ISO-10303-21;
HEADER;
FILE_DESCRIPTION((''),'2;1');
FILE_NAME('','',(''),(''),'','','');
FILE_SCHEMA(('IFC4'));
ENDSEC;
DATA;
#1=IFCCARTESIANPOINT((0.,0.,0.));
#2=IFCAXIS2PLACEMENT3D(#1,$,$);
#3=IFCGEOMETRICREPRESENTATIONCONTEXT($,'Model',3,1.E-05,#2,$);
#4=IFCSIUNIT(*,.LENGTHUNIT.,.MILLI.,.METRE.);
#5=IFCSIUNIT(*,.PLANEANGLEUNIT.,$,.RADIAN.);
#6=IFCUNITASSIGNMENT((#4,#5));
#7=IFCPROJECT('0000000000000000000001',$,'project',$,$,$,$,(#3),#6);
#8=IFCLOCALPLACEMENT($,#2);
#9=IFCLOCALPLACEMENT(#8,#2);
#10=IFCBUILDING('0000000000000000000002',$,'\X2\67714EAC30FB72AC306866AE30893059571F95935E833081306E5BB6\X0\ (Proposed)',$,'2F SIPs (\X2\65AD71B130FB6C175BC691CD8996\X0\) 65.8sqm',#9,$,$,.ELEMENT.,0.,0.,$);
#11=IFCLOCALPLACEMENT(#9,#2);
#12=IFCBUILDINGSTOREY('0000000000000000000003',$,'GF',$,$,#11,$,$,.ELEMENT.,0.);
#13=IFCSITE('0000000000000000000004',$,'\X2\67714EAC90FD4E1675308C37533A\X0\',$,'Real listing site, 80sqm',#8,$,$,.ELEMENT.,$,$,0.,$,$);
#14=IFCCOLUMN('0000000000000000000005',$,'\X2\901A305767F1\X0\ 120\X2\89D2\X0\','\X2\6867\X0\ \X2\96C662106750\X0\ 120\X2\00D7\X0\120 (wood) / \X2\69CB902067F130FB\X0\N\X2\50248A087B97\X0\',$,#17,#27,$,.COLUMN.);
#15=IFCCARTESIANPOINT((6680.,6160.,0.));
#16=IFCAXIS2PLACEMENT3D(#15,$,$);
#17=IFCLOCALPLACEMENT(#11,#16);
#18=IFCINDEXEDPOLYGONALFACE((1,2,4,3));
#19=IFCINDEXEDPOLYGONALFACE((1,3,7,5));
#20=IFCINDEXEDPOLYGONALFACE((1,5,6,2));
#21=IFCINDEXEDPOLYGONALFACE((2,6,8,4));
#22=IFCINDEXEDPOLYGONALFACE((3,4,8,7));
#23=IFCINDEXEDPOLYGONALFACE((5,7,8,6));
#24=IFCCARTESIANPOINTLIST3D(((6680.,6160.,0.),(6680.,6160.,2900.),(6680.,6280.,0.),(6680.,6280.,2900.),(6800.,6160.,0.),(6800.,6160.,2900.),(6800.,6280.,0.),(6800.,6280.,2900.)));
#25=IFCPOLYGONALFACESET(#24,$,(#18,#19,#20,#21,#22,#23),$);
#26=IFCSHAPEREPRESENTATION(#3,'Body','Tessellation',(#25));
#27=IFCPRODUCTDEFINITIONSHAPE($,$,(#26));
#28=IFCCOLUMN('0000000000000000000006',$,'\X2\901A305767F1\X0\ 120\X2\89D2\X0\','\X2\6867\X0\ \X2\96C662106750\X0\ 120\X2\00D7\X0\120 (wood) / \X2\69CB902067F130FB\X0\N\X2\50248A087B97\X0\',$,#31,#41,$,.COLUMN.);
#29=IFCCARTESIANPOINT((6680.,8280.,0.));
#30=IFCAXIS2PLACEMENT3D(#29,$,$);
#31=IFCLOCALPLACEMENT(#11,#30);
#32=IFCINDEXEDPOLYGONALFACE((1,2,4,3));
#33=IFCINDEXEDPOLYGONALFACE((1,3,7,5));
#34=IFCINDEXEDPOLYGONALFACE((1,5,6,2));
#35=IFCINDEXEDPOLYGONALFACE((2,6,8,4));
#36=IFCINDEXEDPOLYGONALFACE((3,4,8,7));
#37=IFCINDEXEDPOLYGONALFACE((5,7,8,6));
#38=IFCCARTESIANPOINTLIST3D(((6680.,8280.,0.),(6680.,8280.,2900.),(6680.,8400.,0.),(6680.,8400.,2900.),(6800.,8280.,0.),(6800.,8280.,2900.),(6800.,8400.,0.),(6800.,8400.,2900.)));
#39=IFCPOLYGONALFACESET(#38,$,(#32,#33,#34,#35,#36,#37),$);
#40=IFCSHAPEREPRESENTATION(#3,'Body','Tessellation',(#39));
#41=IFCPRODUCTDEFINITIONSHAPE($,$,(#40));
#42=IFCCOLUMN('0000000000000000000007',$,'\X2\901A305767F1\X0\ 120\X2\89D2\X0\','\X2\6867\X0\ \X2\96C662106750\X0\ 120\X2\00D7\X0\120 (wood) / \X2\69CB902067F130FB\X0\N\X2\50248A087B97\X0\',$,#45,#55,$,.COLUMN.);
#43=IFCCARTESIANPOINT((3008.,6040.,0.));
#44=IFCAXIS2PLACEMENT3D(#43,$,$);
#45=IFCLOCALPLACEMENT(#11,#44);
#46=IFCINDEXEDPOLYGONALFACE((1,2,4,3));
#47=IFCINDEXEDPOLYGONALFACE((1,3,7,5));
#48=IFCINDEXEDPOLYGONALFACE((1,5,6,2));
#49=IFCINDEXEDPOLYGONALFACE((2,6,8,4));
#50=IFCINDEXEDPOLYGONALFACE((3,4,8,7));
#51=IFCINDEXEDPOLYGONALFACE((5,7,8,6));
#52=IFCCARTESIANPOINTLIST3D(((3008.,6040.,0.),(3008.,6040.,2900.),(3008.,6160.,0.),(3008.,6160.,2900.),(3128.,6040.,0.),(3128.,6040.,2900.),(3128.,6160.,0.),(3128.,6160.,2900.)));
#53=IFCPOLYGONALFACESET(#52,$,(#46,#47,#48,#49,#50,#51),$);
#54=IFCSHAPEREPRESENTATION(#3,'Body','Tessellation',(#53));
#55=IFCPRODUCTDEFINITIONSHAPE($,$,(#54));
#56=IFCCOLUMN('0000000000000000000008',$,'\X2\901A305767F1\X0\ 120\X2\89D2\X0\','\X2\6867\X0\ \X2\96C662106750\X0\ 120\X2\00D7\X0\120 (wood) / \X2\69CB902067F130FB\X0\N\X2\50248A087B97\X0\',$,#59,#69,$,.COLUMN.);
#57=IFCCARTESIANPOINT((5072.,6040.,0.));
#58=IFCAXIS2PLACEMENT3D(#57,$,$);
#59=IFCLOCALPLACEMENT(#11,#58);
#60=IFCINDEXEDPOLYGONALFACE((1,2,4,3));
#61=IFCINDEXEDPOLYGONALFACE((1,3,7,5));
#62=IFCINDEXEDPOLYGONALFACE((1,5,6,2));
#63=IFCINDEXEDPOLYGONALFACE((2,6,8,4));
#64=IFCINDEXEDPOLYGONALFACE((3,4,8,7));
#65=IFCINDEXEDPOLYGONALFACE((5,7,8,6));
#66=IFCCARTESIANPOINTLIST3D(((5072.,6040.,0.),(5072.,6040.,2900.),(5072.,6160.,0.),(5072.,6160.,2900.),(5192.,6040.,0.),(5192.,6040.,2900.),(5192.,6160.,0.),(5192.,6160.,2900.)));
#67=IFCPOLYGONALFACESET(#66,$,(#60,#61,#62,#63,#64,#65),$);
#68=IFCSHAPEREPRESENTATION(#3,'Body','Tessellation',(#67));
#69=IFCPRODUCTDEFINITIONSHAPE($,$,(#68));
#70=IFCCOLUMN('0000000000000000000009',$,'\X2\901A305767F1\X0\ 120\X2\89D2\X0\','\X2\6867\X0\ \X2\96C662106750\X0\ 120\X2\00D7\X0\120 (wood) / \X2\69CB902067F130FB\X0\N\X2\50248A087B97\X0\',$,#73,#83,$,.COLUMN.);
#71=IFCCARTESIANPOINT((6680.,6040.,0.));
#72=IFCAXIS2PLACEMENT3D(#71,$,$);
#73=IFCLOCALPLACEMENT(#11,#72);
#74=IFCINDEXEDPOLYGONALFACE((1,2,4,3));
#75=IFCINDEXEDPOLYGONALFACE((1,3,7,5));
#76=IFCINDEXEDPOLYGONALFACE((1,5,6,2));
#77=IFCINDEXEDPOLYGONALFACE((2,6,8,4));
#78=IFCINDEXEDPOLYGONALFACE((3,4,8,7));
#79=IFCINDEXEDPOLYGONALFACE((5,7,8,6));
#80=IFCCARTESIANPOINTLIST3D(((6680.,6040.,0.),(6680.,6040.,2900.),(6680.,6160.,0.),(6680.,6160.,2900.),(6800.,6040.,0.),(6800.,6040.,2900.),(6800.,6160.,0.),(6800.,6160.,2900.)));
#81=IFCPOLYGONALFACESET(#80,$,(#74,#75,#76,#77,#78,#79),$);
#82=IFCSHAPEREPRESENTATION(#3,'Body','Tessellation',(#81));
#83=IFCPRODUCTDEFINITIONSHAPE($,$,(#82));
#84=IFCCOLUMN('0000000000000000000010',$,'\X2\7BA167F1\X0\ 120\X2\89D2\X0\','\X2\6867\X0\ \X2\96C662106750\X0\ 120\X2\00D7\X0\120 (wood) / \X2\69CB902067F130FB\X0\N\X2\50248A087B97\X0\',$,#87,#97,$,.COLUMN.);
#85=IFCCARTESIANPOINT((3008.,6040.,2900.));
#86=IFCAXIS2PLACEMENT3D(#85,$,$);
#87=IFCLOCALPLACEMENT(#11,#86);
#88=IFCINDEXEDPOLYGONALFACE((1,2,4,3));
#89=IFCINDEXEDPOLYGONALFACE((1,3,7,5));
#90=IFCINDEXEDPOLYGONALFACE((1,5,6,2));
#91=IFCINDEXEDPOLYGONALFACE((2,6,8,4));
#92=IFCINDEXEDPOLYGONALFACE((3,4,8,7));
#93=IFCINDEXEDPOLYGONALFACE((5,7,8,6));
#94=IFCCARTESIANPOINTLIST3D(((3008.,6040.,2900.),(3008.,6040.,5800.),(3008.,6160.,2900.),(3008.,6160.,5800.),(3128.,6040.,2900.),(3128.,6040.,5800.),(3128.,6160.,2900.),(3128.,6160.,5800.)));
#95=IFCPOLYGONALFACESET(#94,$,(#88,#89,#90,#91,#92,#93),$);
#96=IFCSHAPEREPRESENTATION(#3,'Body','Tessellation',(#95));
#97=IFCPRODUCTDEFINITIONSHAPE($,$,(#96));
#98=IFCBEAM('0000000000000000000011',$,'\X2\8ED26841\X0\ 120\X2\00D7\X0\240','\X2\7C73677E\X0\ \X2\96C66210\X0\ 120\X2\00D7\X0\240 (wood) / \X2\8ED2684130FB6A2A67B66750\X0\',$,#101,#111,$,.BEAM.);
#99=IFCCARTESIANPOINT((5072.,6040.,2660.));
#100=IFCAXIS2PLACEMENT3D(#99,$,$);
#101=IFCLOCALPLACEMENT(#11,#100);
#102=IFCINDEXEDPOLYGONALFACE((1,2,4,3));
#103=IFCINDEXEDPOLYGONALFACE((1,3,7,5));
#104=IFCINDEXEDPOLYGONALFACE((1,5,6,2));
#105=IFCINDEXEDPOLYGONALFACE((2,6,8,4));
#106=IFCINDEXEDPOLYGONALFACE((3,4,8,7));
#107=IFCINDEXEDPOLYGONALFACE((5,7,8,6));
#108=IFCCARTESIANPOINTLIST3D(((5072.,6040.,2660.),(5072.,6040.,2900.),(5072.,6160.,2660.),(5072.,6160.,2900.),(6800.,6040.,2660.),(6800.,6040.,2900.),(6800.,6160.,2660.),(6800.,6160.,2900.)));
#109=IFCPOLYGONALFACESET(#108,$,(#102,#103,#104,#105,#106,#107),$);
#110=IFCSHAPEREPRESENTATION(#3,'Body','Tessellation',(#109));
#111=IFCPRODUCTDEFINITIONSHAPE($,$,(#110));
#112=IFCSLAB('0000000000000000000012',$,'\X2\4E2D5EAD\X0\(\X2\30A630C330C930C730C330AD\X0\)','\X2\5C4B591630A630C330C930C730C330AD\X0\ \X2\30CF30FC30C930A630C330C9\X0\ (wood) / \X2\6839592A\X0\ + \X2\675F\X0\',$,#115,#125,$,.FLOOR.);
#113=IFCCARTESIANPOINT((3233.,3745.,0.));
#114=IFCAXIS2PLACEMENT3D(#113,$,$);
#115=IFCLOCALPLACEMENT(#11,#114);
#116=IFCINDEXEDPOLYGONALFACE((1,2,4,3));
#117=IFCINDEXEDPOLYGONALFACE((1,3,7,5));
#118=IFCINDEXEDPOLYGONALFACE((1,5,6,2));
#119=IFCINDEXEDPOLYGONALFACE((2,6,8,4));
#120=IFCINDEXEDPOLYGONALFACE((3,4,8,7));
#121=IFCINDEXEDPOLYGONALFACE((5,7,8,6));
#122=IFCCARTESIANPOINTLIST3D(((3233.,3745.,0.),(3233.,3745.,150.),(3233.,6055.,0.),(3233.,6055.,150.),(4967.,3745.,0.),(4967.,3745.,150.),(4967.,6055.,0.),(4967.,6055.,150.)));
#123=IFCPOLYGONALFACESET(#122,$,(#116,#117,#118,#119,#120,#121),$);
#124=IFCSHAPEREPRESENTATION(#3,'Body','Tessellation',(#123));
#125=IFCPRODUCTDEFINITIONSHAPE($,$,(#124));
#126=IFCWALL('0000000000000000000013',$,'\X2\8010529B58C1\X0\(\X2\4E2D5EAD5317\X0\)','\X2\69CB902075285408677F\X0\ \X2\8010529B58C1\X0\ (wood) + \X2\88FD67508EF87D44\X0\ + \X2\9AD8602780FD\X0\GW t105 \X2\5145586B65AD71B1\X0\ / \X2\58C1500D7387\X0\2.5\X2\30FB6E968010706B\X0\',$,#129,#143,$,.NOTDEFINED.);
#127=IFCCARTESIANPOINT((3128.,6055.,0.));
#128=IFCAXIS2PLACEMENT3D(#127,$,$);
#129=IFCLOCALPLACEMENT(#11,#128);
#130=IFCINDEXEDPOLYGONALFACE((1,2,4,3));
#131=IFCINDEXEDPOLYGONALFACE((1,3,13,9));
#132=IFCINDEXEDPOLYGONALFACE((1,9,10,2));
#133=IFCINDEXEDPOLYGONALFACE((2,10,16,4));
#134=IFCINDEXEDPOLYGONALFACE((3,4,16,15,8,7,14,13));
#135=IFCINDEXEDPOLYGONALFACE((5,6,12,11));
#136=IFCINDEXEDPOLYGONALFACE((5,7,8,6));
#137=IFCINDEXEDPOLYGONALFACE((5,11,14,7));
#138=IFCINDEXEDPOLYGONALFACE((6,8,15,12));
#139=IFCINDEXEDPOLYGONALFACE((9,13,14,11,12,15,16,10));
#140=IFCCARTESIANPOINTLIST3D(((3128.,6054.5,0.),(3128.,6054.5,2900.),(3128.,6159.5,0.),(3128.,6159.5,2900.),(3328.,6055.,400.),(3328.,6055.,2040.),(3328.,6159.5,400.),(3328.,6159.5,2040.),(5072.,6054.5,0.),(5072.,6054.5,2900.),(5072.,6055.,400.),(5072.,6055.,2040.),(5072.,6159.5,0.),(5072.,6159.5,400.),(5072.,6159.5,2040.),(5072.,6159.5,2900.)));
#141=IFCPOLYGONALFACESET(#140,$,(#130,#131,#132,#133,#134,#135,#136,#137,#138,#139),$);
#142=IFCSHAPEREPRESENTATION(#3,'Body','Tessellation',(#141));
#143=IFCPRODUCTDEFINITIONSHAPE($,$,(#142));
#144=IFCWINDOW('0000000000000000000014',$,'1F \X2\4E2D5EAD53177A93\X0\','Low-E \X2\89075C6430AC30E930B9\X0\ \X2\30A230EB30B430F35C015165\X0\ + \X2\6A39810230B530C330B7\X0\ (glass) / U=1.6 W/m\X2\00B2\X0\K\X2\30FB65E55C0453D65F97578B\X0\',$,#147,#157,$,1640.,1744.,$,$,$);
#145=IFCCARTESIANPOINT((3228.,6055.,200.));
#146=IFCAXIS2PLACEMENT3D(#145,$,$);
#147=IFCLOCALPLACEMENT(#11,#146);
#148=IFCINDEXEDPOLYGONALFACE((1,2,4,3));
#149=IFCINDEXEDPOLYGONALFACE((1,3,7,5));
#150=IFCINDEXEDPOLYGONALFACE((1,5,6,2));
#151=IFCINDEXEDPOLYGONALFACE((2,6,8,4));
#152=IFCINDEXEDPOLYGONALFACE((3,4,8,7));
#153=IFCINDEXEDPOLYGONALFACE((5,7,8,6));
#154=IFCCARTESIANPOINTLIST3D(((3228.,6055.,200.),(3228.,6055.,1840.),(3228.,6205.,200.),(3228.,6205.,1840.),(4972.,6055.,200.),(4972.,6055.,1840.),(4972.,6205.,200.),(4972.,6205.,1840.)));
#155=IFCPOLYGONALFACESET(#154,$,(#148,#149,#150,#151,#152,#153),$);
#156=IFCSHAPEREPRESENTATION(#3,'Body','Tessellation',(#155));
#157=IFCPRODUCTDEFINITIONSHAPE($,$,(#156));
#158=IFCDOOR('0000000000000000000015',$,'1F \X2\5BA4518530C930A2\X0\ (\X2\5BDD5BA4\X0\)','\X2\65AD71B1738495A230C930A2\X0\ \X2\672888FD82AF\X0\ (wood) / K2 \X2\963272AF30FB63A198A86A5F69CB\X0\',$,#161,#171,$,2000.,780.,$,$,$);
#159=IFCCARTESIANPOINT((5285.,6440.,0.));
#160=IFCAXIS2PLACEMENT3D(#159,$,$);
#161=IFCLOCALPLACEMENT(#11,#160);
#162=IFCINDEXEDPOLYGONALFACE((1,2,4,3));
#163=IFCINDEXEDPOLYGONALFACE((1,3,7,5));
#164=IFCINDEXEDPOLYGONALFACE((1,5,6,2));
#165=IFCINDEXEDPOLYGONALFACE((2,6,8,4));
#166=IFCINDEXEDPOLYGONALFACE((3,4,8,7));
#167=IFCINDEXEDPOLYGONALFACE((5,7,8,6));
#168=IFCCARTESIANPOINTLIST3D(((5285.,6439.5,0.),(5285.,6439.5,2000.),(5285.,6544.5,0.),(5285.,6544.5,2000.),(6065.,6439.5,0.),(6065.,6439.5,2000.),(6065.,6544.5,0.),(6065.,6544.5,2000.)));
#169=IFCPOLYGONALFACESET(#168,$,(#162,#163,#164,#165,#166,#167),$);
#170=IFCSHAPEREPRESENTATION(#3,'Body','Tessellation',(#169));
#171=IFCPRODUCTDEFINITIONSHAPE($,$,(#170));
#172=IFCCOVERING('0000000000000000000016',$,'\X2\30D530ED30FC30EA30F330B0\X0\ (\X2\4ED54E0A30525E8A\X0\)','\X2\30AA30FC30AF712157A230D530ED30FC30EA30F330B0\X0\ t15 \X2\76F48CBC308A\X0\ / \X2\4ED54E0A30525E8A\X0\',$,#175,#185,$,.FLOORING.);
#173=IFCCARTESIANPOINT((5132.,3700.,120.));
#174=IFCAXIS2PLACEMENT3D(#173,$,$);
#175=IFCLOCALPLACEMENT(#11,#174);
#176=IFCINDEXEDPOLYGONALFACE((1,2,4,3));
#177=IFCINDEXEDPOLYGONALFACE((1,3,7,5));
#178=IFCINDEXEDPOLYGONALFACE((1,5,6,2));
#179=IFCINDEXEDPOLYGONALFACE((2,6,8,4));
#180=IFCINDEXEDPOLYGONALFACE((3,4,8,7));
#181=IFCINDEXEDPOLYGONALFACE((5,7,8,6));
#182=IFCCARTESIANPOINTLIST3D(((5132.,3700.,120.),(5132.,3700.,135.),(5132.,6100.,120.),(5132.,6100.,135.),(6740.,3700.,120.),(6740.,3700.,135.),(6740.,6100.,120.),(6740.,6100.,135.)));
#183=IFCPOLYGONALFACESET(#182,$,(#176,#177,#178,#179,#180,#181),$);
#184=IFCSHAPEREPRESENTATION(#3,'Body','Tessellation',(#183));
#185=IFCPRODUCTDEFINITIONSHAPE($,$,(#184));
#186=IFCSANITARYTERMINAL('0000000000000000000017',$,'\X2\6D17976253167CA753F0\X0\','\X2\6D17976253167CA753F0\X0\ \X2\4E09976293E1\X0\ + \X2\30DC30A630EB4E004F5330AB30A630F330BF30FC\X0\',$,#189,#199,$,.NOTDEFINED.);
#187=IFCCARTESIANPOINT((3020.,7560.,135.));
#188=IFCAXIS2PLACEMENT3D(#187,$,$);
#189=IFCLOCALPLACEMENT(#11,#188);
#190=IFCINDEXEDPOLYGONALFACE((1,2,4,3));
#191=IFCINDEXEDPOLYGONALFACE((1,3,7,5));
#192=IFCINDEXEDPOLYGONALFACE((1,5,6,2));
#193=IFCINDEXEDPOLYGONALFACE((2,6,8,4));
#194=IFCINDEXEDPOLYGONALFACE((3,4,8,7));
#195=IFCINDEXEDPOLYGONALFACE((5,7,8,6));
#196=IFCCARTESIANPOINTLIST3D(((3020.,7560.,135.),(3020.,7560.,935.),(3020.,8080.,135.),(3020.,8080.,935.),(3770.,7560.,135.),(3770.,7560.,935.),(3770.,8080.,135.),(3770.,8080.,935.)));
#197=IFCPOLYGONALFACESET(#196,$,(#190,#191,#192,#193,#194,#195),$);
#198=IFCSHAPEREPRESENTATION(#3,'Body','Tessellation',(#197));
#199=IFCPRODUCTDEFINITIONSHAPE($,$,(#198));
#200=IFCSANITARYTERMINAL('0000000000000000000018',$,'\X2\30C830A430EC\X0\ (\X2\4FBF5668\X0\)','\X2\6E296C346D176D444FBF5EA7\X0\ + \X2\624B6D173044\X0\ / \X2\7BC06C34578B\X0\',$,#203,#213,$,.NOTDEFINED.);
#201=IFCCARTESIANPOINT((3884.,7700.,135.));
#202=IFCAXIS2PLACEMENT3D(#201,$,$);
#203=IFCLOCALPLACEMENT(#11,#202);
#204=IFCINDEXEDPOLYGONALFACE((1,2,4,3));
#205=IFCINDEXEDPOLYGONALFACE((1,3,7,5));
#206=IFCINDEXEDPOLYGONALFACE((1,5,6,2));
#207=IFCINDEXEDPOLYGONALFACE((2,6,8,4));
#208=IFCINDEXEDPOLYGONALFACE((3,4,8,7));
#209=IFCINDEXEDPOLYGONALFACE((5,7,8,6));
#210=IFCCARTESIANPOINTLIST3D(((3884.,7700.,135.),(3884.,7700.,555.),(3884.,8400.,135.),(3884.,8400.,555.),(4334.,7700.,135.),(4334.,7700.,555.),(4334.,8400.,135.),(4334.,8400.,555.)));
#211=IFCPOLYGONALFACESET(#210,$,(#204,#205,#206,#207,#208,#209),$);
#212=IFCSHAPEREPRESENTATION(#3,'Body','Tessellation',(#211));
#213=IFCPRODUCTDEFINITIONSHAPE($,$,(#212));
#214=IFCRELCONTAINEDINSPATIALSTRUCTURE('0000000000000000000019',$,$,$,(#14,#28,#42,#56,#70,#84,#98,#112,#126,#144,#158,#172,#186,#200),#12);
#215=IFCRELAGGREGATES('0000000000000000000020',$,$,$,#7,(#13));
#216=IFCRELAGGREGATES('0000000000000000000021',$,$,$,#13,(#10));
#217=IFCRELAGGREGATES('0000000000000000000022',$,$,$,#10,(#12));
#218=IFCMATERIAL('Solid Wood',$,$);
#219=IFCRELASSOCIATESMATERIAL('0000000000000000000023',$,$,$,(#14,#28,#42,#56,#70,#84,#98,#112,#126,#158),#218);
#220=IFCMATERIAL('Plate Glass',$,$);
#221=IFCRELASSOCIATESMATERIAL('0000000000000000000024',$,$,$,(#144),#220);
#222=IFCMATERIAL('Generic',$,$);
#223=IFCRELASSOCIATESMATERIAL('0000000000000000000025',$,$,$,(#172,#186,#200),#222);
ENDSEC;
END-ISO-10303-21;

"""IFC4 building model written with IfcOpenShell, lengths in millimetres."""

from ifc_helpers import new_model, si_unit, frame, frame_2d, origin, place, context, project, spatial, rectangle, extrude, material, element, fill, save


model = new_model("IFC4")

# Units and contexts
model_context = context("Model", 3, precision=1e-05, world=origin())
ifc_project = project(units=[si_unit("LENGTHUNIT", "METRE", prefix="MILLI"), si_unit("PLANEANGLEUNIT", "RADIAN")], contexts=[model_context])

# Site, building, storey
site_placement = place(None, origin())
site = spatial("IfcSite", under=ifc_project, at=site_placement, Name="東京都世田谷区", ObjectType="Real listing site, 80sqm", CompositionType="ELEMENT", RefElevation=0.0)
building_placement = place(site_placement, origin())
building = spatial("IfcBuilding", under=site, at=building_placement, Name="東京・犬と暮らす土間広めの家 (Proposed)", ObjectType="2F SIPs (断熱・気密重視) 65.8sqm", CompositionType="ELEMENT", ElevationOfRefHeight=0.0, ElevationOfTerrain=0.0)
storey_placement = place(building_placement, origin())
storey = spatial("IfcBuildingStorey", under=building, at=storey_placement, Name="GF", CompositionType="ELEMENT", Elevation=0.0)

# Columns
ifc_material_1 = material(Name="Solid Wood")
column_1_placement = place(storey_placement, frame((6680.0, 6160.0, 0.0)))
element("IfcColumn", 1, at=column_1_placement, inside=storey, material=ifc_material_1, Name="通し柱 120角", Description="桧 集成材 120×120 (wood) / 構造柱・N値計算", PredefinedType="COLUMN", context=model_context, shape_type="SweptSolid", body=[
    extrude(rectangle(XDim=120.0, YDim=120.0, at=frame_2d((60.0, 60.0))), frame((6680.0, 6160.0, 0.0)), (0.0, 0.0, 1.0), 2900.0),
])
column_2_placement = place(storey_placement, frame((6680.0, 8280.0, 0.0)))
element("IfcColumn", 2, at=column_2_placement, inside=storey, material=ifc_material_1, Name="通し柱 120角", Description="桧 集成材 120×120 (wood) / 構造柱・N値計算", PredefinedType="COLUMN", context=model_context, shape_type="SweptSolid", body=[
    extrude(rectangle(XDim=120.0, YDim=120.0, at=frame_2d((60.0, 60.0))), frame((6680.0, 8280.0, 0.0)), (0.0, 0.0, 1.0), 2900.0),
])
column_3_placement = place(storey_placement, frame((3008.0, 6040.0, 0.0)))
element("IfcColumn", 3, at=column_3_placement, inside=storey, material=ifc_material_1, Name="通し柱 120角", Description="桧 集成材 120×120 (wood) / 構造柱・N値計算", PredefinedType="COLUMN", context=model_context, shape_type="SweptSolid", body=[
    extrude(rectangle(XDim=120.0, YDim=120.0, at=frame_2d((60.0, 60.0))), frame((3008.0, 6040.0, 0.0)), (0.0, 0.0, 1.0), 2900.0),
])
column_4_placement = place(storey_placement, frame((5072.0, 6040.0, 0.0)))
element("IfcColumn", 4, at=column_4_placement, inside=storey, material=ifc_material_1, Name="通し柱 120角", Description="桧 集成材 120×120 (wood) / 構造柱・N値計算", PredefinedType="COLUMN", context=model_context, shape_type="SweptSolid", body=[
    extrude(rectangle(XDim=120.0, YDim=120.0, at=frame_2d((60.0, 60.0))), frame((5072.0, 6040.0, 0.0)), (0.0, 0.0, 1.0), 2900.0),
])
column_5_placement = place(storey_placement, frame((6680.0, 6040.0, 0.0)))
element("IfcColumn", 5, at=column_5_placement, inside=storey, material=ifc_material_1, Name="通し柱 120角", Description="桧 集成材 120×120 (wood) / 構造柱・N値計算", PredefinedType="COLUMN", context=model_context, shape_type="SweptSolid", body=[
    extrude(rectangle(XDim=120.0, YDim=120.0, at=frame_2d((60.0, 60.0))), frame((6680.0, 6040.0, 0.0)), (0.0, 0.0, 1.0), 2900.0),
])
column_6_placement = place(storey_placement, frame((3008.0, 6040.0, 2900.0)))
element("IfcColumn", 6, at=column_6_placement, inside=storey, material=ifc_material_1, Name="管柱 120角", Description="桧 集成材 120×120 (wood) / 構造柱・N値計算", PredefinedType="COLUMN", context=model_context, shape_type="SweptSolid", body=[
    extrude(rectangle(XDim=120.0, YDim=120.0, at=frame_2d((60.0, 60.0))), frame((3008.0, 6040.0, 2900.0)), (0.0, 0.0, 1.0), 2900.0),
])

# Beam
beam_1_placement = place(storey_placement, frame((5072.0, 6040.0, 2660.0)))
element("IfcBeam", 7, at=beam_1_placement, inside=storey, material=ifc_material_1, Name="軒桁 120×240", Description="米松 集成 120×240 (wood) / 軒桁・横架材", PredefinedType="BEAM", context=model_context, shape_type="SweptSolid", body=[
    extrude(rectangle(XDim=1728.0, YDim=120.0, at=frame_2d((864.0, 60.0))), frame((5072.0, 6040.0, 2660.0)), (0.0, 0.0, 1.0), 240.0),
])

# Slab
slab_placement = place(storey_placement, frame((3233.0, 3745.0, 0.0)))
element("IfcSlab", 8, at=slab_placement, inside=storey, material=ifc_material_1, Name="中庭(ウッドデッキ)", Description="屋外ウッドデッキ ハードウッド (wood) / 根太 + 束", PredefinedType="FLOOR", context=model_context, shape_type="SweptSolid", body=[
    extrude(rectangle(XDim=1734.0, YDim=2310.0, at=frame_2d((867.0, 1155.0))), frame((3233.0, 3745.0, 0.0)), (0.0, 0.0, 1.0), 150.0),
])

# Wall, opening, window
wall_1_placement = place(storey_placement, frame((3128.0, 6055.0, 0.0)))
wall_1 = element("IfcWall", 9, at=wall_1_placement, inside=storey, material=ifc_material_1, Name="耐力壁(中庭北)", Description="構造用合板 耐力壁 (wood) + 製材軸組 + 高性能GW t105 充填断熱 / 壁倍率2.5・準耐火", PredefinedType="NOTDEFINED", context=model_context, shape_type="SweptSolid", body=[
    extrude(rectangle(XDim=1944.0, YDim=105.0, at=frame_2d((972.0, 52.0))), frame((3128.0, 6055.0, 0.0)), (0.0, 0.0, 1.0), 2900.0),
])
opening_placement = place(storey_placement, frame((3228.0, 6055.0, 200.0)))
opening = element("IfcOpeningElement", 10, at=opening_placement, cuts=wall_1, PredefinedType="NOTDEFINED", context=model_context, shape_type="SweptSolid", body=[
    extrude(rectangle(XDim=1744.0, YDim=150.0, at=frame_2d((872.0, 75.0))), frame((3228.0, 6055.0, 200.0)), (0.0, 0.0, 1.0), 1640.0),
])
ifc_material_2 = material(Name="Plate Glass")
window_placement = place(storey_placement, frame((3228.0, 6055.0, 200.0)))
window = element("IfcWindow", 11, at=window_placement, inside=storey, material=ifc_material_2, Name="1F 中庭北窓", Description="Low-E 複層ガラス アルゴン封入 + 樹脂サッシ (glass) / U=1.6 W/m²K・日射取得型", OverallHeight=1640.0, OverallWidth=1744.0, context=model_context, shape_type="SweptSolid", body=[
    extrude(rectangle(XDim=1744.0, YDim=150.0, at=frame_2d((872.0, 75.0))), frame((3228.0, 6055.0, 200.0)), (0.0, 0.0, 1.0), 1640.0),
])
fill(opening, window)

# Door
door_placement = place(storey_placement, frame((5285.0, 6440.0, 0.0)))
element("IfcDoor", 12, at=door_placement, inside=storey, material=ifc_material_1, Name="1F 室内ドア (寝室)", Description="断熱玄関ドア 木製芯 (wood) / K2 防犯・採風機構", OverallHeight=2000.0, OverallWidth=780.0, context=model_context, shape_type="SweptSolid", body=[
    extrude(rectangle(XDim=780.0, YDim=105.0, at=frame_2d((390.0, 52.0))), frame((5285.0, 6440.0, 0.0)), (0.0, 0.0, 1.0), 2000.0),
])

# Covering
ifc_material_3 = material(Name="Generic")
covering_placement = place(storey_placement, frame((5132.0, 3700.0, 120.0)))
element("IfcCovering", 13, at=covering_placement, inside=storey, material=ifc_material_3, Name="フローリング (仕上げ床)", Description="オーク無垢フローリング t15 直貼り / 仕上げ床", PredefinedType="FLOORING", context=model_context, shape_type="SweptSolid", body=[
    extrude(rectangle(XDim=1608.0, YDim=2400.0, at=frame_2d((804.0, 1200.0))), frame((5132.0, 3700.0, 120.0)), (0.0, 0.0, 1.0), 15.0),
])

# Sanitary terminals
sanitary_terminal_1_placement = place(storey_placement, frame((3020.0, 7560.0, 135.0)))
element("IfcSanitaryTerminal", 14, at=sanitary_terminal_1_placement, inside=storey, material=ifc_material_3, Name="洗面化粧台", Description="洗面化粧台 三面鏡 + ボウル一体カウンター", PredefinedType="NOTDEFINED", context=model_context, shape_type="SweptSolid", body=[
    extrude(rectangle(XDim=750.0, YDim=520.0, at=frame_2d((375.0, 260.0))), frame((3020.0, 7560.0, 135.0)), (0.0, 0.0, 1.0), 800.0),
])
sanitary_terminal_2_placement = place(storey_placement, frame((3884.0, 7700.0, 135.0)))
element("IfcSanitaryTerminal", 15, at=sanitary_terminal_2_placement, inside=storey, material=ifc_material_3, Name="トイレ (便器)", Description="温水洗浄便座 + 手洗い / 節水型", PredefinedType="NOTDEFINED", context=model_context, shape_type="SweptSolid", body=[
    extrude(rectangle(XDim=450.0, YDim=700.0, at=frame_2d((225.0, 350.0))), frame((3884.0, 7700.0, 135.0)), (0.0, 0.0, 1.0), 420.0),
])

save(model, "model.ifc")
